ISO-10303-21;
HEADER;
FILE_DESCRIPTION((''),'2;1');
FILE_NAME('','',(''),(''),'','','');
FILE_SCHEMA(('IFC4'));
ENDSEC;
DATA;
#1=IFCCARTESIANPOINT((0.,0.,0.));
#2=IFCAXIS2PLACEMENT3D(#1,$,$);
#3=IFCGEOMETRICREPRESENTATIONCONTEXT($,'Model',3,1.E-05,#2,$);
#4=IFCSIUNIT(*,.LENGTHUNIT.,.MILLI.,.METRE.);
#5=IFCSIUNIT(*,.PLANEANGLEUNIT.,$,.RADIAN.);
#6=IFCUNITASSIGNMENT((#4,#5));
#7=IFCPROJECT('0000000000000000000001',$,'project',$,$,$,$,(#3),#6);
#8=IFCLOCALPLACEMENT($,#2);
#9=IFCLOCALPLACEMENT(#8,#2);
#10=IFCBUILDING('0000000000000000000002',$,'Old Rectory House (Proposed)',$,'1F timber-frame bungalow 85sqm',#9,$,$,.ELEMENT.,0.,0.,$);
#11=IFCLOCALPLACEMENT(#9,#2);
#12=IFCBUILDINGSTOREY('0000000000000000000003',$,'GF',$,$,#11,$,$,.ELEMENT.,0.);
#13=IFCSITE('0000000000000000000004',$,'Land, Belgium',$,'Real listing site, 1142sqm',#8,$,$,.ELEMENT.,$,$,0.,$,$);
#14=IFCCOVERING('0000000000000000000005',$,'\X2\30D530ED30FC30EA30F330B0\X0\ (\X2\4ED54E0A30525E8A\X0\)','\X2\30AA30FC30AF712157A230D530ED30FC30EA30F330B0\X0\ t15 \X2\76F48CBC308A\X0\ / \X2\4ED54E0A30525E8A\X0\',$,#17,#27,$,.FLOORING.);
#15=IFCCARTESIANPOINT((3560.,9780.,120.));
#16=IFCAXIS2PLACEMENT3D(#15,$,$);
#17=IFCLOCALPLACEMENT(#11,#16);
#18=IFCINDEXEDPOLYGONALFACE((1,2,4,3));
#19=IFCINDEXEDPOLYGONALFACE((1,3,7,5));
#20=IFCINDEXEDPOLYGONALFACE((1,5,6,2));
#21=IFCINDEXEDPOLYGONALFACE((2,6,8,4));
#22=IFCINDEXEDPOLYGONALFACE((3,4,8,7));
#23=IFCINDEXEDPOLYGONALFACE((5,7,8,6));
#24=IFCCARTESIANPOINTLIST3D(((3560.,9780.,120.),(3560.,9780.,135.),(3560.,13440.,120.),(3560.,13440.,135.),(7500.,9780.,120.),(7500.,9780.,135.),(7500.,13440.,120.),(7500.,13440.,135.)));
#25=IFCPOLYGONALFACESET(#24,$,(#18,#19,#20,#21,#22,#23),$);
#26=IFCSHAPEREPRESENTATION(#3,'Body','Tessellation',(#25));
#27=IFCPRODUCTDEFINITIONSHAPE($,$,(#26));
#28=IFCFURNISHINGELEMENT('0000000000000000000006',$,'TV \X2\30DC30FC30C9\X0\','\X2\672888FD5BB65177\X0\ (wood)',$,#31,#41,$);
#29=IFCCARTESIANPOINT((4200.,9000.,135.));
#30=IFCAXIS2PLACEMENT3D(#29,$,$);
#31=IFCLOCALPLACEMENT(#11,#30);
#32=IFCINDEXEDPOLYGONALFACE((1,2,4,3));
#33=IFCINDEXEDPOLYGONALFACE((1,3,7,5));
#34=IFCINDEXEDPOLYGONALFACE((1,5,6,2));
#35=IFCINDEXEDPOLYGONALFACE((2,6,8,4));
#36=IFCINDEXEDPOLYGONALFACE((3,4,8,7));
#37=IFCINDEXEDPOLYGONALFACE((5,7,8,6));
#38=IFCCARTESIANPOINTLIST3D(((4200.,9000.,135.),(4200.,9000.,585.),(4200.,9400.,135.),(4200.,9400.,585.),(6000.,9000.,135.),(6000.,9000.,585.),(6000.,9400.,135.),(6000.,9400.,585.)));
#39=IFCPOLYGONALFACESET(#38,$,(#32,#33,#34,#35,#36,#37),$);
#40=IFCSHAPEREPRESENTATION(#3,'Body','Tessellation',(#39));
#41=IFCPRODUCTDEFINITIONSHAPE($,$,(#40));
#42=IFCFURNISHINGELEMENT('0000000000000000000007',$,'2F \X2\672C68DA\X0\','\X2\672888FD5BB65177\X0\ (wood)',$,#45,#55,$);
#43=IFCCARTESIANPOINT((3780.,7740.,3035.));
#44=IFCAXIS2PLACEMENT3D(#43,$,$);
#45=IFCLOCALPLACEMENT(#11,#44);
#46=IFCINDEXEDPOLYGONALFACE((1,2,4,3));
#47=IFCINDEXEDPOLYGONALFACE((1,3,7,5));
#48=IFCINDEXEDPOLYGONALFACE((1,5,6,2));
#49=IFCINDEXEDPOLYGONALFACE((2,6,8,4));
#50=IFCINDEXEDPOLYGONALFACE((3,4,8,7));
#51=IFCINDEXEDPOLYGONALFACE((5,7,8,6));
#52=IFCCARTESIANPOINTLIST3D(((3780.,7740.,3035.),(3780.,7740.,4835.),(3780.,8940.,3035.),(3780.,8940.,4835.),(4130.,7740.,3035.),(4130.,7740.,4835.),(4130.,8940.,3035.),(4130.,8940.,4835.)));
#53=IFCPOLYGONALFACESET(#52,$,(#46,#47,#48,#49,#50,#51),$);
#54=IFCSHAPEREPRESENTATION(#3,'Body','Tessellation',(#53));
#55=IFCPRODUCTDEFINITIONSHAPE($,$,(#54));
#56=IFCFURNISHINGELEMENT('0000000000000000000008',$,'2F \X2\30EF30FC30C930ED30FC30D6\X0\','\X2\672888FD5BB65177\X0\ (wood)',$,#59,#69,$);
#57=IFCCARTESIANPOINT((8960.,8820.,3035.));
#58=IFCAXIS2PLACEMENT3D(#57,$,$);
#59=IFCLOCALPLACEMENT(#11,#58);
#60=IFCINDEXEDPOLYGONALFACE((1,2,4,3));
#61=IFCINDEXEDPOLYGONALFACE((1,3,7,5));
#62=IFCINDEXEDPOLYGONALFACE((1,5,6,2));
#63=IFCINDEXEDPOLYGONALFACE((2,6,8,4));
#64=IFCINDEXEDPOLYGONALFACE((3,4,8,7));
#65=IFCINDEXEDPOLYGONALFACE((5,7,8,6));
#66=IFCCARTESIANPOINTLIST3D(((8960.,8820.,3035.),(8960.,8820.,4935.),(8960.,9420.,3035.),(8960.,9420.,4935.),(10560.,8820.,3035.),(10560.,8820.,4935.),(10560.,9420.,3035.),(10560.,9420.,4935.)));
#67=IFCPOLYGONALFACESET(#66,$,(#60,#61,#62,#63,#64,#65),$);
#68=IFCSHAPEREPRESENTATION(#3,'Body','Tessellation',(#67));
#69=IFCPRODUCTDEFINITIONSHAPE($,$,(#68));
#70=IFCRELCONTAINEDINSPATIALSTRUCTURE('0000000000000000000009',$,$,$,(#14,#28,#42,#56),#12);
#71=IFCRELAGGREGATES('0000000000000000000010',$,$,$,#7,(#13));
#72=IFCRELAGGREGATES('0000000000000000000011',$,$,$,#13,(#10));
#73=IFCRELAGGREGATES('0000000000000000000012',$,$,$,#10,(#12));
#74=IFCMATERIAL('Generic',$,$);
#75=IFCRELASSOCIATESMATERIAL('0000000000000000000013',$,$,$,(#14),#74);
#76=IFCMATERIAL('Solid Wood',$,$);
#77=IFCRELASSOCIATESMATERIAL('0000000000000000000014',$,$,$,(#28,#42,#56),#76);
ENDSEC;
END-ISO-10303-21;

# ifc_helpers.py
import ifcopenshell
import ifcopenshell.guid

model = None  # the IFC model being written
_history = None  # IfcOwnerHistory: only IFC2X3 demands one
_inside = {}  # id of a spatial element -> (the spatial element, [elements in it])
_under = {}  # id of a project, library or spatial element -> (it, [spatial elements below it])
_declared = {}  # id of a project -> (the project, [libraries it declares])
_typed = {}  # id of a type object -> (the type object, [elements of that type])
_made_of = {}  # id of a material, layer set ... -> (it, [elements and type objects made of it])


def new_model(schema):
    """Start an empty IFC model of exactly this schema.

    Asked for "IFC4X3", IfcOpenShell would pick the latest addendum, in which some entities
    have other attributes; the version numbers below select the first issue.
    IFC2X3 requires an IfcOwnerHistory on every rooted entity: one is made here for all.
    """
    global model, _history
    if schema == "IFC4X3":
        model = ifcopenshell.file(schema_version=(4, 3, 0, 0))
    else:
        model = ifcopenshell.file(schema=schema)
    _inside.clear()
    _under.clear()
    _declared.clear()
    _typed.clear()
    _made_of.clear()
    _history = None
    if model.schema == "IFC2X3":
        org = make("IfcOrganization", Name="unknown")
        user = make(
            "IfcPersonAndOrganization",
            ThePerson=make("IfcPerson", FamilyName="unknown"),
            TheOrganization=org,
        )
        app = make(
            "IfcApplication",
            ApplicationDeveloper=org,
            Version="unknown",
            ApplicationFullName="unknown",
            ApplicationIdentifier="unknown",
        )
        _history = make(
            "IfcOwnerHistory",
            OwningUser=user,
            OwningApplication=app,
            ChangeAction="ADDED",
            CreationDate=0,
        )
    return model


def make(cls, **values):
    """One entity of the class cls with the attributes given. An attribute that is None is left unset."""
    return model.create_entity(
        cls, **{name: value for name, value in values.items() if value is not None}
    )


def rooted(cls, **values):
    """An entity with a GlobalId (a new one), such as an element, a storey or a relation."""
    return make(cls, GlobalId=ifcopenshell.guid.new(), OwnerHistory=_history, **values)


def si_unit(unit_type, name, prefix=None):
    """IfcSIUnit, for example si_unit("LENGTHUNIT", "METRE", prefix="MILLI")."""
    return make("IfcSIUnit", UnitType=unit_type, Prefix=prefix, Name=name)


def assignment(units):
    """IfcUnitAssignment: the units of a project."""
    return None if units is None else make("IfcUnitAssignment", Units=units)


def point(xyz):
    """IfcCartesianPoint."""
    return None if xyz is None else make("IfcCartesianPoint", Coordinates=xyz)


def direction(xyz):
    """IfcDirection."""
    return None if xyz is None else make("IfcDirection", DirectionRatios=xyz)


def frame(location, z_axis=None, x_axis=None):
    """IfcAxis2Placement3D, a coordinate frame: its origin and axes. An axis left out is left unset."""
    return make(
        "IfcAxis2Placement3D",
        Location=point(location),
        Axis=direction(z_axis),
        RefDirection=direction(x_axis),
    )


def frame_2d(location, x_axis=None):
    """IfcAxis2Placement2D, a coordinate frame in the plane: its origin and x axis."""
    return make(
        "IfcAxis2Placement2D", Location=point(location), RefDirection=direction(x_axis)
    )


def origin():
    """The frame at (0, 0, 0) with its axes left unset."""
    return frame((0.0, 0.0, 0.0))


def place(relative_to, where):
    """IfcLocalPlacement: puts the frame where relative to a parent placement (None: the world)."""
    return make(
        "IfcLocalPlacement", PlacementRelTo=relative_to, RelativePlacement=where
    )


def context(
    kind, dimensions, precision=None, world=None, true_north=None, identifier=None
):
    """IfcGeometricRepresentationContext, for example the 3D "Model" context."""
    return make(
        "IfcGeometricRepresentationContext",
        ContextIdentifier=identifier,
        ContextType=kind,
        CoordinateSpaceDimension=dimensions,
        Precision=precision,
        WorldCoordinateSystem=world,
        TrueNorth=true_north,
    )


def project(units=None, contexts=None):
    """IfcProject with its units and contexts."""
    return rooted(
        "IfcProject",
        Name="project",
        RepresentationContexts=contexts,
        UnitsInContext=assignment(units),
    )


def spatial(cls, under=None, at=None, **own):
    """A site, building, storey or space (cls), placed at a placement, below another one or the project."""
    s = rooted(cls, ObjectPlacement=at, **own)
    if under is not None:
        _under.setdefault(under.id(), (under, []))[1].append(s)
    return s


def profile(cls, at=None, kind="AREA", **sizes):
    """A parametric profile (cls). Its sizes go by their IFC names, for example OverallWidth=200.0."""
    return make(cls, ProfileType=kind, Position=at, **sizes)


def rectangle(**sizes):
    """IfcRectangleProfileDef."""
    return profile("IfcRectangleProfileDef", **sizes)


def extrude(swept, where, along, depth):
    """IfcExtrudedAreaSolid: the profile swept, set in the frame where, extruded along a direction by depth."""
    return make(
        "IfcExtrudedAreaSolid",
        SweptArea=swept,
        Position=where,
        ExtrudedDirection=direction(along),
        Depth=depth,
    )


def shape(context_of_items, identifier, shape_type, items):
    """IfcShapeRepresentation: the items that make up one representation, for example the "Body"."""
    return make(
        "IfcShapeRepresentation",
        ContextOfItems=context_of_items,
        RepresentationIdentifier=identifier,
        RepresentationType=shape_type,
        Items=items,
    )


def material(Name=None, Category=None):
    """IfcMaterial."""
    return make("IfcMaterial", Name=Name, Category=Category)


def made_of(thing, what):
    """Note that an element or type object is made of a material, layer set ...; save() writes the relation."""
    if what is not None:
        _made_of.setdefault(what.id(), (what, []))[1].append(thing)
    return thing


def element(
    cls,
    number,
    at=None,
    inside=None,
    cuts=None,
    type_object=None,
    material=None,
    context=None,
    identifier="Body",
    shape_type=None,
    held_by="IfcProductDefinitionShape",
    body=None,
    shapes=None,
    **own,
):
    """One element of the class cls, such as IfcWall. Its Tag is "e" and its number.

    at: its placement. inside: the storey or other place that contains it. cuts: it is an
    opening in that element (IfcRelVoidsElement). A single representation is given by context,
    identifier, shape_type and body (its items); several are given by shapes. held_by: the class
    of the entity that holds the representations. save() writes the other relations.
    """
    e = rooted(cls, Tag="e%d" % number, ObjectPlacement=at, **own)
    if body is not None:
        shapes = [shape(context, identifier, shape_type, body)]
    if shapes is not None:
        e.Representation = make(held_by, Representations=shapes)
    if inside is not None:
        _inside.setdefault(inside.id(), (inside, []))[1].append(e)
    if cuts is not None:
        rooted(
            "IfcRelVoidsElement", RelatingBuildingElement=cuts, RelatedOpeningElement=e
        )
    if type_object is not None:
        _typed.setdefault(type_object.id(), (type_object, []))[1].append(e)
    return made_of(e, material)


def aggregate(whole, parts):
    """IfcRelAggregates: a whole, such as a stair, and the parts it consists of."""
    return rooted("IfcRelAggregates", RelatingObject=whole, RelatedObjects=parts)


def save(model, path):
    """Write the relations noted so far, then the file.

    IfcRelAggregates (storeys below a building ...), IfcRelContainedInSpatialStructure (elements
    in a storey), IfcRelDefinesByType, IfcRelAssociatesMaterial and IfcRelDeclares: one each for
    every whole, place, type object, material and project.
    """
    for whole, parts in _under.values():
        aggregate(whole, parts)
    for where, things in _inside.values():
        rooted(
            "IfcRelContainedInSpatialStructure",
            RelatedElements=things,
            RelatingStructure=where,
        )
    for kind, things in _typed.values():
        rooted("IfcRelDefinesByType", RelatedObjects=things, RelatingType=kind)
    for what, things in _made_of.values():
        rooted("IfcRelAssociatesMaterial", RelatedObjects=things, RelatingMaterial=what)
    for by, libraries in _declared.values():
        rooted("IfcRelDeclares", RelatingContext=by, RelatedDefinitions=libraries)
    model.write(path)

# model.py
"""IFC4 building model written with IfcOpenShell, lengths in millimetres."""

from ifc_helpers import new_model, si_unit, frame, frame_2d, origin, place, context, project, spatial, rectangle, extrude, material, element, save


model = new_model("IFC4")

# Units and contexts
model_context = context("Model", 3, precision=1e-05, world=origin())
ifc_project = project(units=[si_unit("LENGTHUNIT", "METRE", prefix="MILLI"), si_unit("PLANEANGLEUNIT", "RADIAN")], contexts=[model_context])

# Site, building, storey
site_placement = place(None, origin())
site = spatial("IfcSite", under=ifc_project, at=site_placement, Name="Land, Belgium", ObjectType="Real listing site, 1142sqm", CompositionType="ELEMENT", RefElevation=0.0)
building_placement = place(site_placement, origin())
building = spatial("IfcBuilding", under=site, at=building_placement, Name="Old Rectory House (Proposed)", ObjectType="1F timber-frame bungalow 85sqm", CompositionType="ELEMENT", ElevationOfRefHeight=0.0, ElevationOfTerrain=0.0)
storey_placement = place(building_placement, origin())
storey = spatial("IfcBuildingStorey", under=building, at=storey_placement, Name="GF", CompositionType="ELEMENT", Elevation=0.0)

# Shared definitions
ifc_material_1 = material(Name="Solid Wood")

# Shared definitions
ifc_material_2 = material(Name="Generic")

# Covering
covering_placement = place(storey_placement, frame((3560.0, 9780.0, 120.0)))
element("IfcCovering", 1, at=covering_placement, inside=storey, material=ifc_material_2, Name="フローリング (仕上げ床)", Description="オーク無垢フローリング t15 直貼り / 仕上げ床", PredefinedType="FLOORING", context=model_context, shape_type="SweptSolid", body=[
    extrude(rectangle(XDim=3940.0, YDim=3660.0, at=frame_2d((1970.0, 1830.0))), frame((3560.0, 9780.0, 120.0)), (0.0, 0.0, 1.0), 15.0),
])

# Furnishing elements
furnishing_1_placement = place(storey_placement, frame((4200.0, 9000.0, 135.0)))
element("IfcFurnishingElement", 2, at=furnishing_1_placement, inside=storey, material=ifc_material_1, Name="TV ボード", Description="木製家具 (wood)", context=model_context, shape_type="SweptSolid", body=[
    extrude(rectangle(XDim=1800.0, YDim=400.0, at=frame_2d((900.0, 200.0))), frame((4200.0, 9000.0, 135.0)), (0.0, 0.0, 1.0), 450.0),
])
furnishing_2_placement = place(storey_placement, frame((3780.0, 7740.0, 3035.0)))
element("IfcFurnishingElement", 3, at=furnishing_2_placement, inside=storey, material=ifc_material_1, Name="2F 本棚", Description="木製家具 (wood)", context=model_context, shape_type="SweptSolid", body=[
    extrude(rectangle(XDim=350.0, YDim=1200.0, at=frame_2d((175.0, 600.0))), frame((3780.0, 7740.0, 3035.0)), (0.0, 0.0, 1.0), 1800.0),
])
furnishing_3_placement = place(storey_placement, frame((8960.0, 8820.0, 3035.0)))
element("IfcFurnishingElement", 4, at=furnishing_3_placement, inside=storey, material=ifc_material_1, Name="2F ワードローブ", Description="木製家具 (wood)", context=model_context, shape_type="SweptSolid", body=[
    extrude(rectangle(XDim=1600.0, YDim=600.0, at=frame_2d((800.0, 300.0))), frame((8960.0, 8820.0, 3035.0)), (0.0, 0.0, 1.0), 1900.0),
])

save(model, "model.ifc")
